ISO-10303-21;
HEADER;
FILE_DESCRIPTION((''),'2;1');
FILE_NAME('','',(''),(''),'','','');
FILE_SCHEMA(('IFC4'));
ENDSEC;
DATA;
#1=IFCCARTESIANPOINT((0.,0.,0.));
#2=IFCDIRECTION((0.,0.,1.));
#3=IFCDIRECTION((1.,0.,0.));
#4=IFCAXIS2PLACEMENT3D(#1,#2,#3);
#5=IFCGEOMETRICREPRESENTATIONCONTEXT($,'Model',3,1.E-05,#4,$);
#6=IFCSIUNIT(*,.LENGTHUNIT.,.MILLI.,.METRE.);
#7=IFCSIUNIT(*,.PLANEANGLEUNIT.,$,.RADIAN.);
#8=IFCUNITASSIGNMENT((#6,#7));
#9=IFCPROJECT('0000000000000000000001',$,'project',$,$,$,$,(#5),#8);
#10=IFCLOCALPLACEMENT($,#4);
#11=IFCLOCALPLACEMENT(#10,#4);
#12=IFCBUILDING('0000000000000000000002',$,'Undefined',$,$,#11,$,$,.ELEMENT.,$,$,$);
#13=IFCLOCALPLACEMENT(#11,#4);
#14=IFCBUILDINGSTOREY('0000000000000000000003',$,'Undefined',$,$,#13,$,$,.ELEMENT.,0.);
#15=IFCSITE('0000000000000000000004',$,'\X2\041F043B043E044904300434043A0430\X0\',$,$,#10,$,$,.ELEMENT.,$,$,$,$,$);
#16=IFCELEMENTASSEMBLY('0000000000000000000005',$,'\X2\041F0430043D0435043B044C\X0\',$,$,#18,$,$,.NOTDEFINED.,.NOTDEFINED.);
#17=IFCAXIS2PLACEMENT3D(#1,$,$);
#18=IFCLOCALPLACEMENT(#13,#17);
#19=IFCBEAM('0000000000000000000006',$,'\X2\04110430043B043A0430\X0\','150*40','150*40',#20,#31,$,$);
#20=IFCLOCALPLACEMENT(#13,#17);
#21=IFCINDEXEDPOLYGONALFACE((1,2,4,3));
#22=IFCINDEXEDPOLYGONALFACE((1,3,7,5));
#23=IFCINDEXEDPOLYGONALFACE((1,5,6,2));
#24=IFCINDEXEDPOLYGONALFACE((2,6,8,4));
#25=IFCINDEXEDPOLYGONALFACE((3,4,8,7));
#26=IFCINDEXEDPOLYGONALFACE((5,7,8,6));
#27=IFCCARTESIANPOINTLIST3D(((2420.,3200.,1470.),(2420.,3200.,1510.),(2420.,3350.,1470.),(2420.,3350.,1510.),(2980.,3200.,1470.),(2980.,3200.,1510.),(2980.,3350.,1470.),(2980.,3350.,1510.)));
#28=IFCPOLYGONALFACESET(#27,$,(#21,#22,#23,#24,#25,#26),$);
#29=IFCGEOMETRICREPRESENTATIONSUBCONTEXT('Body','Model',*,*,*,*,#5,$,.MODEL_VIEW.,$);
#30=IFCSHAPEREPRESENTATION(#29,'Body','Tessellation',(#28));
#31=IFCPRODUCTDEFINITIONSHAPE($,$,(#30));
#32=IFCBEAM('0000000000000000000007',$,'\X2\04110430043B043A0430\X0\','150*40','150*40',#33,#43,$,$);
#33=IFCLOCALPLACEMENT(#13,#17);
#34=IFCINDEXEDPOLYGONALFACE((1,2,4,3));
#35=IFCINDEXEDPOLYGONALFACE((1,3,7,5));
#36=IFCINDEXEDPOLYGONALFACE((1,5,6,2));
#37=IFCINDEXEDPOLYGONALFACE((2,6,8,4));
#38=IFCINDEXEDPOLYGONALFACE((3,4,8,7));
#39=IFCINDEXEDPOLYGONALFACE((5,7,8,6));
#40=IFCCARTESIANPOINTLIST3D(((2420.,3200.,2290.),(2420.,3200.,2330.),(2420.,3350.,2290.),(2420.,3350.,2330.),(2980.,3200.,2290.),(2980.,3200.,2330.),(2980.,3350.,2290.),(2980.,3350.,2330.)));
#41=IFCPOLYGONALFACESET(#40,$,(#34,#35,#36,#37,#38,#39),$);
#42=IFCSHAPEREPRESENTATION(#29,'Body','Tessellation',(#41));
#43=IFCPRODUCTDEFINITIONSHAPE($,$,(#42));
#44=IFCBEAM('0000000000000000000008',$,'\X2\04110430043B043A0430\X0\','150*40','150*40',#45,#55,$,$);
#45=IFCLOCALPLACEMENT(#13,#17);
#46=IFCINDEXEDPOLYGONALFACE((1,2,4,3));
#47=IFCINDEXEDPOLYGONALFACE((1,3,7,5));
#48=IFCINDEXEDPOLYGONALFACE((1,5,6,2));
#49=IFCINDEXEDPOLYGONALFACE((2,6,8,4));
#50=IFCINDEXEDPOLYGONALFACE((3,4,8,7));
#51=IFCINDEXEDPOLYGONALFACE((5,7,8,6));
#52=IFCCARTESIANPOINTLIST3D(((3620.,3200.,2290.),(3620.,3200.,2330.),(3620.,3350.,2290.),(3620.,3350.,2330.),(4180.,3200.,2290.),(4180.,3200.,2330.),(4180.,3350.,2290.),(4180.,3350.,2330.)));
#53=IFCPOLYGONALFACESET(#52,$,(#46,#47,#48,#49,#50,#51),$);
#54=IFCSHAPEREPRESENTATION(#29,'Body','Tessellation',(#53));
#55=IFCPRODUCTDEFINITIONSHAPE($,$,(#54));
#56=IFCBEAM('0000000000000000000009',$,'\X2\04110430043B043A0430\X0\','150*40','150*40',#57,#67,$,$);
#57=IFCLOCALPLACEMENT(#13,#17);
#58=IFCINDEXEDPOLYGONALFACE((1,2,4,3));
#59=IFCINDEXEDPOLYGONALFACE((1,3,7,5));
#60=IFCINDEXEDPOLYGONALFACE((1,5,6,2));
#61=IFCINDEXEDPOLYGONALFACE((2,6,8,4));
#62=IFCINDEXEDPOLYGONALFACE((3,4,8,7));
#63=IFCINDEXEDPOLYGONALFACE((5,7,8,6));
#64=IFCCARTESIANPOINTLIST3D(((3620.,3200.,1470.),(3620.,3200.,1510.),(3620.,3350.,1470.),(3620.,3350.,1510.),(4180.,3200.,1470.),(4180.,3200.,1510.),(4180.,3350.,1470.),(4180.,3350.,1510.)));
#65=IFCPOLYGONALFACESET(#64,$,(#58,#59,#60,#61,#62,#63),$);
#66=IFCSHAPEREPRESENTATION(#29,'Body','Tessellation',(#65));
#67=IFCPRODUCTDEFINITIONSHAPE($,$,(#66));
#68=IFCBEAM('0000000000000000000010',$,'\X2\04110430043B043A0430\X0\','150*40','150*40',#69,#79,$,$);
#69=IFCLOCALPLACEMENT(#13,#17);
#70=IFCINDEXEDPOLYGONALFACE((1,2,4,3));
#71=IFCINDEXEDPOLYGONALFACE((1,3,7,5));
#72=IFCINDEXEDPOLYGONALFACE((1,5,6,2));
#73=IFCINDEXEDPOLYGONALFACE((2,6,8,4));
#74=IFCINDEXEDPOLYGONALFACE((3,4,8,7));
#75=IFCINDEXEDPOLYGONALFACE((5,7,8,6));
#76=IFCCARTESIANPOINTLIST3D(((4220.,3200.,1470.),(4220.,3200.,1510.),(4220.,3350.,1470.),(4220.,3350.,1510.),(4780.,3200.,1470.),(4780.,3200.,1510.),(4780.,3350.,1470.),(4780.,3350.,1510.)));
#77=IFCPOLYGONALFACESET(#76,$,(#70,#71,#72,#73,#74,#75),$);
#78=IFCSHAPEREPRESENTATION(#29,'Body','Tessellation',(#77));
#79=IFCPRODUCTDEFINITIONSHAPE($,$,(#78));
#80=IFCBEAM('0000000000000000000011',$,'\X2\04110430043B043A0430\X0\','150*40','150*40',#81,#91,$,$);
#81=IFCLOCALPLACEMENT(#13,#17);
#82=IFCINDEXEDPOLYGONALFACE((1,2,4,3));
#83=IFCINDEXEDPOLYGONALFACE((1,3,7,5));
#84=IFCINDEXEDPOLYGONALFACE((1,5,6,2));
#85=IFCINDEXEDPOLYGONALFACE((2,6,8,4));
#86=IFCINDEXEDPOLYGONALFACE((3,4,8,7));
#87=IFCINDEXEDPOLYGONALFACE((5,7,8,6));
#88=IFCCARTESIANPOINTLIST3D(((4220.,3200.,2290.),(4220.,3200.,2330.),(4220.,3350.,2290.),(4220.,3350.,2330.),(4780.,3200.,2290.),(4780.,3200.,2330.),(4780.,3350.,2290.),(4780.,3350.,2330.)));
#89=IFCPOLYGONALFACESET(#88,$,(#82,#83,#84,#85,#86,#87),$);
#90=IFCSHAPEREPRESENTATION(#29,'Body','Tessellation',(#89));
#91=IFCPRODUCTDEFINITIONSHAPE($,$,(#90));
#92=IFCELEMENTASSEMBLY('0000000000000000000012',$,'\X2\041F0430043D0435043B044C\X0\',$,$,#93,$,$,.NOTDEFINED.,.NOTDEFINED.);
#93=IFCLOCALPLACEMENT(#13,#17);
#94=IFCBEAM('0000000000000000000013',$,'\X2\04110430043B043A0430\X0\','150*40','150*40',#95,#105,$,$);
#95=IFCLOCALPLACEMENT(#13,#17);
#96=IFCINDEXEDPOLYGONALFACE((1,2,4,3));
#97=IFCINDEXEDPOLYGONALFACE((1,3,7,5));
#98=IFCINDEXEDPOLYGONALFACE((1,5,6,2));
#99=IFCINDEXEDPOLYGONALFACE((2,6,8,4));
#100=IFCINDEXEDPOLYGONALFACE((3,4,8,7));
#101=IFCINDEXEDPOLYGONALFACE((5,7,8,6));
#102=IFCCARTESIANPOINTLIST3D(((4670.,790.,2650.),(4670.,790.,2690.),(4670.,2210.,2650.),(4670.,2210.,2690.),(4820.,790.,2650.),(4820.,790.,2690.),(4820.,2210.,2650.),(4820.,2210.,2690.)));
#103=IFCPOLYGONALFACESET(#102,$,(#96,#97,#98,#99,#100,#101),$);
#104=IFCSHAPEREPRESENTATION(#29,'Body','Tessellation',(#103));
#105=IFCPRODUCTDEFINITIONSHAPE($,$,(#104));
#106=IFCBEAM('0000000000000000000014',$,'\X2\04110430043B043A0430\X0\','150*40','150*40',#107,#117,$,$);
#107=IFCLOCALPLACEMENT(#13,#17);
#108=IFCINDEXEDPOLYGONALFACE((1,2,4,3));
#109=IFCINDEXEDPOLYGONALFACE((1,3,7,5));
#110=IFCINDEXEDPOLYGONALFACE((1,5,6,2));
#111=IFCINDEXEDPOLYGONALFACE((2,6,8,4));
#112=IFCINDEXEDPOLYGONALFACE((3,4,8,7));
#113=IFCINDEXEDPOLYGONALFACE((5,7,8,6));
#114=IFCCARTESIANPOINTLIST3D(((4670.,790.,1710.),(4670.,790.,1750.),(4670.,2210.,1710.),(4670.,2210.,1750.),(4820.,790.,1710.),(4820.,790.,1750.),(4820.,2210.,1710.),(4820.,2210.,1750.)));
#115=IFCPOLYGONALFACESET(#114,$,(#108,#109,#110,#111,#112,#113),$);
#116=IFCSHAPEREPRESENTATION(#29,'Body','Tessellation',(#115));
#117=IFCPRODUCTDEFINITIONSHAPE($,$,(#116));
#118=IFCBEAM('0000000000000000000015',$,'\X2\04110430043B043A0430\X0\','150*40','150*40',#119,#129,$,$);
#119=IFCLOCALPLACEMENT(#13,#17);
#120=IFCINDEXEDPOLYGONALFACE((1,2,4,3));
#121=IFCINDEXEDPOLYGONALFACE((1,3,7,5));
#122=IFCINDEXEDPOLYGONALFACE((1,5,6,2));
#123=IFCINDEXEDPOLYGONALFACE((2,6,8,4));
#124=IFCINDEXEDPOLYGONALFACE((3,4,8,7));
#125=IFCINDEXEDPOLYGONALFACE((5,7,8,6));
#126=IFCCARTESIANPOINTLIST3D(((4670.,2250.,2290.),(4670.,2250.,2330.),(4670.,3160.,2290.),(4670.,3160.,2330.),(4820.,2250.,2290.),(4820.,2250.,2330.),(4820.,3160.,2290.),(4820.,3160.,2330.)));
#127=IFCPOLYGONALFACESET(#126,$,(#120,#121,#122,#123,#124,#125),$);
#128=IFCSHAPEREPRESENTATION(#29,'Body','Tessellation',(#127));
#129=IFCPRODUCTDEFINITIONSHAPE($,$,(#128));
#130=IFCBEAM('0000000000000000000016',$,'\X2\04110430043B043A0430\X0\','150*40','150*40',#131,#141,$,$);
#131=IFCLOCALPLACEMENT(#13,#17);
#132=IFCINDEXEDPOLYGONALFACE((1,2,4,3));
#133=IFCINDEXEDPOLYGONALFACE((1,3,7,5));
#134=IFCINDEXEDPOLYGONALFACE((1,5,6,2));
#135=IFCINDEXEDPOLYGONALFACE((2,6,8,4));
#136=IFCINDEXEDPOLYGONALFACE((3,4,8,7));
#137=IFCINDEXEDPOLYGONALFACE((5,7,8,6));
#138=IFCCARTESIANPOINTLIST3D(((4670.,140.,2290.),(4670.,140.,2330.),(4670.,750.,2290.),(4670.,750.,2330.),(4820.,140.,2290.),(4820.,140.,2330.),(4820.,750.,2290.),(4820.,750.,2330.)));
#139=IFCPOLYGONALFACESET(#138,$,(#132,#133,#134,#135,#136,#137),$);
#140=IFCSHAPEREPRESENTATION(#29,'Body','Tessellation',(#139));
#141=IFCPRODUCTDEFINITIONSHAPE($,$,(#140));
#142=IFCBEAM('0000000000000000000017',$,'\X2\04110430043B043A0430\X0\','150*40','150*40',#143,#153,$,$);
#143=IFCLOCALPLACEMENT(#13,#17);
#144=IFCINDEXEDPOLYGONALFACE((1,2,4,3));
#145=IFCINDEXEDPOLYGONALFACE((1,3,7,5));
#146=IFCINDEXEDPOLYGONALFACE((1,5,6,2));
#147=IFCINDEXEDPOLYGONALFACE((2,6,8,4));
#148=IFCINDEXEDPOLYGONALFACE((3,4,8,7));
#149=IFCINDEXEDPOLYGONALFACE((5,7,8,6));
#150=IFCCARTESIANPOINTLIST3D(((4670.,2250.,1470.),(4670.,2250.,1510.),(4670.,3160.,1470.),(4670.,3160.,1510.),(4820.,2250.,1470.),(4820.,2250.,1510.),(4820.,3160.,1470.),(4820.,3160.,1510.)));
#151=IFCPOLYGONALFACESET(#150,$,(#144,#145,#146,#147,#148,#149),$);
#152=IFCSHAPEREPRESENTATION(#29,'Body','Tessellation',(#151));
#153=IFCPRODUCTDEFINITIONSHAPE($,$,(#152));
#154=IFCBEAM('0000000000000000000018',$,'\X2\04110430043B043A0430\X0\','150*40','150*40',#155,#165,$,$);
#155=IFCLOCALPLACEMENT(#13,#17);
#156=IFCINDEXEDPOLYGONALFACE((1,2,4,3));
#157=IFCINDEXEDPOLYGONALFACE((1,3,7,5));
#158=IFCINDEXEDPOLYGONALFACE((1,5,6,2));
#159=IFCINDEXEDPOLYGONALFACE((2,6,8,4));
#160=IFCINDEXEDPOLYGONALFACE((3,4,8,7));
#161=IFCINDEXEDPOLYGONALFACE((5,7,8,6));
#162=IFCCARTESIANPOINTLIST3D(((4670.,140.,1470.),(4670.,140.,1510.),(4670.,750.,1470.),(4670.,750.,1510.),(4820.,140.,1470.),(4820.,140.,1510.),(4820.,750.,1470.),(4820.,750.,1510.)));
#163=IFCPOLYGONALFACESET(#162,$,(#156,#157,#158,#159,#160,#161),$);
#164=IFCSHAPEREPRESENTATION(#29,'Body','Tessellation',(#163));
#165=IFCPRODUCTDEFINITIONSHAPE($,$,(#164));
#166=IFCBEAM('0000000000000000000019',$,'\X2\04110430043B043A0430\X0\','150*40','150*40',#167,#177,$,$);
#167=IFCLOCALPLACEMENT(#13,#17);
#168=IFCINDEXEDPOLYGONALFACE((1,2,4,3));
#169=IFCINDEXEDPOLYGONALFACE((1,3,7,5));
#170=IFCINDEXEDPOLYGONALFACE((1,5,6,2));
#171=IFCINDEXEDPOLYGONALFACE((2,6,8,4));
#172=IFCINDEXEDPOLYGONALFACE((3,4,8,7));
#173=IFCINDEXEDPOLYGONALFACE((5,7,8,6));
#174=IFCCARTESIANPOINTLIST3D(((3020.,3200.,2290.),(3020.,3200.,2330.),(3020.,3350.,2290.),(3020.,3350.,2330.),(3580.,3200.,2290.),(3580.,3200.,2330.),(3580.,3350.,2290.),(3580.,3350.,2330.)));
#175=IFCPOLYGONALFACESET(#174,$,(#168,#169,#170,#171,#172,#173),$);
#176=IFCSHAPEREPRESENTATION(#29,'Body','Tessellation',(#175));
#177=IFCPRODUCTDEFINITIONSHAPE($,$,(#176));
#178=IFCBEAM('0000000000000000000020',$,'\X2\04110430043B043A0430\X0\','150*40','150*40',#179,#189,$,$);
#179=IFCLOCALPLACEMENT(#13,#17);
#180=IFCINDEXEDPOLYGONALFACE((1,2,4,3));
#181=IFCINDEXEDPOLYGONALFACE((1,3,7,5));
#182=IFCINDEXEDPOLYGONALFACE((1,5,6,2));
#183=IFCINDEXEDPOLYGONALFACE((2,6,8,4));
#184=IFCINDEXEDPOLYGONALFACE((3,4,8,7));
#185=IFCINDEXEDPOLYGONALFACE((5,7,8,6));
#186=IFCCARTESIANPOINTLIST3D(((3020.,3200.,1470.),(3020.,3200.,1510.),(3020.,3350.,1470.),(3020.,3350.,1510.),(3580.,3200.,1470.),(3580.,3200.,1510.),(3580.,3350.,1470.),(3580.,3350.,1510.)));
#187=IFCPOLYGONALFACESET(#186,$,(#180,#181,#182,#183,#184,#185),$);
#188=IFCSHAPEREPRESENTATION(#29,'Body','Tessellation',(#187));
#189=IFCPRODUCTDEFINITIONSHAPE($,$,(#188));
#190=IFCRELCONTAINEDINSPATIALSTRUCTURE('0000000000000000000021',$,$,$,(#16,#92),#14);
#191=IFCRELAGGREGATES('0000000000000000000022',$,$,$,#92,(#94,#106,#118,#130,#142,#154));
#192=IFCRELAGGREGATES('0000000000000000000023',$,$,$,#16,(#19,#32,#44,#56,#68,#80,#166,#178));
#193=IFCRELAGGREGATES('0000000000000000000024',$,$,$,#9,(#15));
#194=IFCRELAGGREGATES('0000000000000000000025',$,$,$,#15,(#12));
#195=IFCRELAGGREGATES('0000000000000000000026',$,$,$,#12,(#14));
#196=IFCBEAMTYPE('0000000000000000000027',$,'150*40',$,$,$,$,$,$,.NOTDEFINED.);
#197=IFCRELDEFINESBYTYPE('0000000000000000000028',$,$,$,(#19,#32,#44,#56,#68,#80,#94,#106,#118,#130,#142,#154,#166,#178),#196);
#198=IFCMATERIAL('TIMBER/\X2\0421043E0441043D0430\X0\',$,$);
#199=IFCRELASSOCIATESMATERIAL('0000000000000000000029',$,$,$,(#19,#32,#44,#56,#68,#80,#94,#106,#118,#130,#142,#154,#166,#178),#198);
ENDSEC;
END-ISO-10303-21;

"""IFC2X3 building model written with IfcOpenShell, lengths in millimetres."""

from ifc_helpers import new_model, si_unit, frame, origin_with_axes, origin_2d_with_axis, place, context, subcontext, project, spatial, rectangle, extrude, material, type_object, element, aggregate, save


model = new_model("IFC2X3")

# Units and contexts
model_context = context("Model", 3, precision=1e-05, world=origin_with_axes())
body_context = subcontext(model_context, "Body", "Model", "MODEL_VIEW")
ifc_project = project(units=[si_unit("LENGTHUNIT", "METRE", prefix="MILLI"), si_unit("PLANEANGLEUNIT", "RADIAN")], contexts=[model_context])

# Site, building, storey
site_placement = place(None, origin_with_axes())
site = spatial("IfcSite", under=ifc_project, at=site_placement, Name="Площадка", CompositionType="ELEMENT")
building_placement = place(site_placement, origin_with_axes())
building = spatial("IfcBuilding", under=site, at=building_placement, Name="Undefined", CompositionType="ELEMENT")
storey_placement = place(building_placement, origin_with_axes())
storey = spatial("IfcBuildingStorey", under=building, at=storey_placement, Name="Undefined", CompositionType="ELEMENT", Elevation=0.0)

# Element assembly, beams
assembly_1_placement = place(storey_placement, origin_with_axes())
assembly_1 = element("IfcElementAssembly", 1, at=assembly_1_placement, inside=storey, Name="Панель", AssemblyPlace="NOTDEFINED", PredefinedType="NOTDEFINED")
ifc_material = material(Name="TIMBER/Сосна")
beam_type_1 = type_object("IfcBeamType", Name="150*40", PredefinedType="NOTDEFINED")
beam_1_placement = place(assembly_1_placement, frame((2420.0, 3275.0, 1490.0), z_axis=(0.0, 1.0, 0.0), x_axis=(1.0, 0.0, 0.0)))
beam_1 = element("IfcBeam", 2, at=beam_1_placement, type_object=beam_type_1, material=ifc_material, Name="Балка", Description="150*40", ObjectType="150*40", context=body_context, shape_type="SweptSolid", body=[
    extrude(rectangle(XDim=40.0, YDim=150.0, at=origin_2d_with_axis()), frame((560.0, 0.0, 0.0), z_axis=(-1.0, 0.0, 0.0), x_axis=(0.0, -1.0, 0.0)), (0.0, 0.0, 1.0), 560.0),
])
beam_2_placement = place(assembly_1_placement, frame((2420.0, 3275.0, 2310.0), z_axis=(0.0, 1.0, 0.0), x_axis=(1.0, 0.0, 0.0)))
beam_2 = element("IfcBeam", 3, at=beam_2_placement, type_object=beam_type_1, material=ifc_material, Name="Балка", Description="150*40", ObjectType="150*40", context=body_context, shape_type="SweptSolid", body=[
    extrude(rectangle(XDim=40.0, YDim=150.0, at=origin_2d_with_axis()), frame((560.0, 0.0, 0.0), z_axis=(-1.0, 0.0, 0.0), x_axis=(0.0, -1.0, 0.0)), (0.0, 0.0, 1.0), 560.0),
])
beam_3_placement = place(assembly_1_placement, frame((3620.0, 3275.0, 2310.0), z_axis=(0.0, 1.0, 0.0), x_axis=(1.0, 0.0, 0.0)))
beam_3 = element("IfcBeam", 4, at=beam_3_placement, type_object=beam_type_1, material=ifc_material, Name="Балка", Description="150*40", ObjectType="150*40", context=body_context, shape_type="SweptSolid", body=[
    extrude(rectangle(XDim=40.0, YDim=150.0, at=origin_2d_with_axis()), frame((560.0, 0.0, 0.0), z_axis=(-1.0, 0.0, 0.0), x_axis=(0.0, -1.0, 0.0)), (0.0, 0.0, 1.0), 560.0),
])
beam_4_placement = place(assembly_1_placement, frame((3620.0, 3275.0, 1490.0), z_axis=(0.0, 1.0, 0.0), x_axis=(1.0, 0.0, 0.0)))
beam_4 = element("IfcBeam", 5, at=beam_4_placement, type_object=beam_type_1, material=ifc_material, Name="Балка", Description="150*40", ObjectType="150*40", context=body_context, shape_type="SweptSolid", body=[
    extrude(rectangle(XDim=40.0, YDim=150.0, at=origin_2d_with_axis()), frame((560.0, 0.0, 0.0), z_axis=(-1.0, 0.0, 0.0), x_axis=(0.0, -1.0, 0.0)), (0.0, 0.0, 1.0), 560.0),
])
beam_5_placement = place(assembly_1_placement, frame((4220.0, 3275.0, 1490.0), z_axis=(0.0, 1.0, 0.0), x_axis=(1.0, 0.0, 0.0)))
beam_5 = element("IfcBeam", 6, at=beam_5_placement, type_object=beam_type_1, material=ifc_material, Name="Балка", Description="150*40", ObjectType="150*40", context=body_context, shape_type="SweptSolid", body=[
    extrude(rectangle(XDim=40.0, YDim=150.0, at=origin_2d_with_axis()), frame((560.0, 0.0, 0.0), z_axis=(-1.0, 0.0, 0.0), x_axis=(0.0, -1.0, 0.0)), (0.0, 0.0, 1.0), 560.0),
])
beam_6_placement = place(assembly_1_placement, frame((4220.0, 3275.0, 2310.0), z_axis=(0.0, 1.0, 0.0), x_axis=(1.0, 0.0, 0.0)))
beam_6 = element("IfcBeam", 7, at=beam_6_placement, type_object=beam_type_1, material=ifc_material, Name="Балка", Description="150*40", ObjectType="150*40", context=body_context, shape_type="SweptSolid", body=[
    extrude(rectangle(XDim=40.0, YDim=150.0, at=origin_2d_with_axis()), frame((560.0, 0.0, 0.0), z_axis=(-1.0, 0.0, 0.0), x_axis=(0.0, -1.0, 0.0)), (0.0, 0.0, 1.0), 560.0),
])

# Element assembly, beams
assembly_2_placement = place(storey_placement, origin_with_axes())
assembly_2 = element("IfcElementAssembly", 8, at=assembly_2_placement, inside=storey, Name="Панель", AssemblyPlace="NOTDEFINED", PredefinedType="NOTDEFINED")
beam_7_placement = place(assembly_2_placement, frame((4745.0, 790.0, 2670.0), z_axis=(-1.0, 0.0, 0.0), x_axis=(0.0, 1.0, 0.0)))
beam_7 = element("IfcBeam", 9, at=beam_7_placement, type_object=beam_type_1, material=ifc_material, Name="Балка", Description="150*40", ObjectType="150*40", context=body_context, shape_type="SweptSolid", body=[
    extrude(rectangle(XDim=40.0, YDim=150.0, at=origin_2d_with_axis()), frame((1420.0, 0.0, 0.0), z_axis=(-1.0, 0.0, 0.0), x_axis=(0.0, -1.0, 0.0)), (0.0, 0.0, 1.0), 1420.0),
])
beam_8_placement = place(assembly_2_placement, frame((4745.0, 790.0, 1730.0), z_axis=(-1.0, 0.0, 0.0), x_axis=(0.0, 1.0, 0.0)))
beam_8 = element("IfcBeam", 10, at=beam_8_placement, type_object=beam_type_1, material=ifc_material, Name="Балка", Description="150*40", ObjectType="150*40", context=body_context, shape_type="SweptSolid", body=[
    extrude(rectangle(XDim=40.0, YDim=150.0, at=origin_2d_with_axis()), frame((1420.0, 0.0, 0.0), z_axis=(-1.0, 0.0, 0.0), x_axis=(0.0, -1.0, 0.0)), (0.0, 0.0, 1.0), 1420.0),
])
beam_9_placement = place(assembly_2_placement, frame((4745.0, 2250.0, 2310.0), z_axis=(-1.0, 0.0, 0.0), x_axis=(0.0, 1.0, 0.0)))
beam_9 = element("IfcBeam", 11, at=beam_9_placement, type_object=beam_type_1, material=ifc_material, Name="Балка", Description="150*40", ObjectType="150*40", context=body_context, shape_type="SweptSolid", body=[
    extrude(rectangle(XDim=40.0, YDim=150.0, at=origin_2d_with_axis()), frame((910.0, 0.0, 0.0), z_axis=(-1.0, 0.0, 0.0), x_axis=(0.0, -1.0, 0.0)), (0.0, 0.0, 1.0), 910.0),
])
beam_10_placement = place(assembly_2_placement, frame((4745.0, 140.0, 2310.0), z_axis=(-1.0, 0.0, 0.0), x_axis=(0.0, 1.0, 0.0)))
beam_10 = element("IfcBeam", 12, at=beam_10_placement, type_object=beam_type_1, material=ifc_material, Name="Балка", Description="150*40", ObjectType="150*40", context=body_context, shape_type="SweptSolid", body=[
    extrude(rectangle(XDim=40.0, YDim=150.0, at=origin_2d_with_axis()), frame((610.0, 0.0, 0.0), z_axis=(-1.0, 0.0, 0.0), x_axis=(0.0, -1.0, 0.0)), (0.0, 0.0, 1.0), 610.0),
])
beam_11_placement = place(assembly_2_placement, frame((4745.0, 2250.0, 1490.0), z_axis=(-1.0, 0.0, 0.0), x_axis=(0.0, 1.0, 0.0)))
beam_11 = element("IfcBeam", 13, at=beam_11_placement, type_object=beam_type_1, material=ifc_material, Name="Балка", Description="150*40", ObjectType="150*40", context=body_context, shape_type="SweptSolid", body=[
    extrude(rectangle(XDim=40.0, YDim=150.0, at=origin_2d_with_axis()), frame((910.0, 0.0, 0.0), z_axis=(-1.0, 0.0, 0.0), x_axis=(0.0, -1.0, 0.0)), (0.0, 0.0, 1.0), 910.0),
])
beam_12_placement = place(assembly_2_placement, frame((4745.0, 140.0, 1490.0), z_axis=(-1.0, 0.0, 0.0), x_axis=(0.0, 1.0, 0.0)))
beam_12 = element("IfcBeam", 14, at=beam_12_placement, type_object=beam_type_1, material=ifc_material, Name="Балка", Description="150*40", ObjectType="150*40", context=body_context, shape_type="SweptSolid", body=[
    extrude(rectangle(XDim=40.0, YDim=150.0, at=origin_2d_with_axis()), frame((610.0, 0.0, 0.0), z_axis=(-1.0, 0.0, 0.0), x_axis=(0.0, -1.0, 0.0)), (0.0, 0.0, 1.0), 610.0),
])
aggregate(assembly_2, [beam_7, beam_8, beam_9, beam_10, beam_11, beam_12])

# Beams
beam_13_placement = place(assembly_1_placement, frame((3020.0, 3275.0, 2310.0), z_axis=(0.0, 1.0, 0.0), x_axis=(1.0, 0.0, 0.0)))
beam_13 = element("IfcBeam", 15, at=beam_13_placement, type_object=beam_type_1, material=ifc_material, Name="Балка", Description="150*40", ObjectType="150*40", context=body_context, shape_type="SweptSolid", body=[
    extrude(rectangle(XDim=40.0, YDim=150.0, at=origin_2d_with_axis()), frame((560.0, 0.0, 0.0), z_axis=(-1.0, 0.0, 0.0), x_axis=(0.0, -1.0, 0.0)), (0.0, 0.0, 1.0), 560.0),
])
beam_14_placement = place(assembly_1_placement, frame((3020.0, 3275.0, 1490.0), z_axis=(0.0, 1.0, 0.0), x_axis=(1.0, 0.0, 0.0)))
beam_14 = element("IfcBeam", 16, at=beam_14_placement, type_object=beam_type_1, material=ifc_material, Name="Балка", Description="150*40", ObjectType="150*40", context=body_context, shape_type="SweptSolid", body=[
    extrude(rectangle(XDim=40.0, YDim=150.0, at=origin_2d_with_axis()), frame((560.0, 0.0, 0.0), z_axis=(-1.0, 0.0, 0.0), x_axis=(0.0, -1.0, 0.0)), (0.0, 0.0, 1.0), 560.0),
])
aggregate(assembly_1, [beam_1, beam_2, beam_3, beam_4, beam_5, beam_6, beam_13, beam_14])

save(model, "model.ifc")
